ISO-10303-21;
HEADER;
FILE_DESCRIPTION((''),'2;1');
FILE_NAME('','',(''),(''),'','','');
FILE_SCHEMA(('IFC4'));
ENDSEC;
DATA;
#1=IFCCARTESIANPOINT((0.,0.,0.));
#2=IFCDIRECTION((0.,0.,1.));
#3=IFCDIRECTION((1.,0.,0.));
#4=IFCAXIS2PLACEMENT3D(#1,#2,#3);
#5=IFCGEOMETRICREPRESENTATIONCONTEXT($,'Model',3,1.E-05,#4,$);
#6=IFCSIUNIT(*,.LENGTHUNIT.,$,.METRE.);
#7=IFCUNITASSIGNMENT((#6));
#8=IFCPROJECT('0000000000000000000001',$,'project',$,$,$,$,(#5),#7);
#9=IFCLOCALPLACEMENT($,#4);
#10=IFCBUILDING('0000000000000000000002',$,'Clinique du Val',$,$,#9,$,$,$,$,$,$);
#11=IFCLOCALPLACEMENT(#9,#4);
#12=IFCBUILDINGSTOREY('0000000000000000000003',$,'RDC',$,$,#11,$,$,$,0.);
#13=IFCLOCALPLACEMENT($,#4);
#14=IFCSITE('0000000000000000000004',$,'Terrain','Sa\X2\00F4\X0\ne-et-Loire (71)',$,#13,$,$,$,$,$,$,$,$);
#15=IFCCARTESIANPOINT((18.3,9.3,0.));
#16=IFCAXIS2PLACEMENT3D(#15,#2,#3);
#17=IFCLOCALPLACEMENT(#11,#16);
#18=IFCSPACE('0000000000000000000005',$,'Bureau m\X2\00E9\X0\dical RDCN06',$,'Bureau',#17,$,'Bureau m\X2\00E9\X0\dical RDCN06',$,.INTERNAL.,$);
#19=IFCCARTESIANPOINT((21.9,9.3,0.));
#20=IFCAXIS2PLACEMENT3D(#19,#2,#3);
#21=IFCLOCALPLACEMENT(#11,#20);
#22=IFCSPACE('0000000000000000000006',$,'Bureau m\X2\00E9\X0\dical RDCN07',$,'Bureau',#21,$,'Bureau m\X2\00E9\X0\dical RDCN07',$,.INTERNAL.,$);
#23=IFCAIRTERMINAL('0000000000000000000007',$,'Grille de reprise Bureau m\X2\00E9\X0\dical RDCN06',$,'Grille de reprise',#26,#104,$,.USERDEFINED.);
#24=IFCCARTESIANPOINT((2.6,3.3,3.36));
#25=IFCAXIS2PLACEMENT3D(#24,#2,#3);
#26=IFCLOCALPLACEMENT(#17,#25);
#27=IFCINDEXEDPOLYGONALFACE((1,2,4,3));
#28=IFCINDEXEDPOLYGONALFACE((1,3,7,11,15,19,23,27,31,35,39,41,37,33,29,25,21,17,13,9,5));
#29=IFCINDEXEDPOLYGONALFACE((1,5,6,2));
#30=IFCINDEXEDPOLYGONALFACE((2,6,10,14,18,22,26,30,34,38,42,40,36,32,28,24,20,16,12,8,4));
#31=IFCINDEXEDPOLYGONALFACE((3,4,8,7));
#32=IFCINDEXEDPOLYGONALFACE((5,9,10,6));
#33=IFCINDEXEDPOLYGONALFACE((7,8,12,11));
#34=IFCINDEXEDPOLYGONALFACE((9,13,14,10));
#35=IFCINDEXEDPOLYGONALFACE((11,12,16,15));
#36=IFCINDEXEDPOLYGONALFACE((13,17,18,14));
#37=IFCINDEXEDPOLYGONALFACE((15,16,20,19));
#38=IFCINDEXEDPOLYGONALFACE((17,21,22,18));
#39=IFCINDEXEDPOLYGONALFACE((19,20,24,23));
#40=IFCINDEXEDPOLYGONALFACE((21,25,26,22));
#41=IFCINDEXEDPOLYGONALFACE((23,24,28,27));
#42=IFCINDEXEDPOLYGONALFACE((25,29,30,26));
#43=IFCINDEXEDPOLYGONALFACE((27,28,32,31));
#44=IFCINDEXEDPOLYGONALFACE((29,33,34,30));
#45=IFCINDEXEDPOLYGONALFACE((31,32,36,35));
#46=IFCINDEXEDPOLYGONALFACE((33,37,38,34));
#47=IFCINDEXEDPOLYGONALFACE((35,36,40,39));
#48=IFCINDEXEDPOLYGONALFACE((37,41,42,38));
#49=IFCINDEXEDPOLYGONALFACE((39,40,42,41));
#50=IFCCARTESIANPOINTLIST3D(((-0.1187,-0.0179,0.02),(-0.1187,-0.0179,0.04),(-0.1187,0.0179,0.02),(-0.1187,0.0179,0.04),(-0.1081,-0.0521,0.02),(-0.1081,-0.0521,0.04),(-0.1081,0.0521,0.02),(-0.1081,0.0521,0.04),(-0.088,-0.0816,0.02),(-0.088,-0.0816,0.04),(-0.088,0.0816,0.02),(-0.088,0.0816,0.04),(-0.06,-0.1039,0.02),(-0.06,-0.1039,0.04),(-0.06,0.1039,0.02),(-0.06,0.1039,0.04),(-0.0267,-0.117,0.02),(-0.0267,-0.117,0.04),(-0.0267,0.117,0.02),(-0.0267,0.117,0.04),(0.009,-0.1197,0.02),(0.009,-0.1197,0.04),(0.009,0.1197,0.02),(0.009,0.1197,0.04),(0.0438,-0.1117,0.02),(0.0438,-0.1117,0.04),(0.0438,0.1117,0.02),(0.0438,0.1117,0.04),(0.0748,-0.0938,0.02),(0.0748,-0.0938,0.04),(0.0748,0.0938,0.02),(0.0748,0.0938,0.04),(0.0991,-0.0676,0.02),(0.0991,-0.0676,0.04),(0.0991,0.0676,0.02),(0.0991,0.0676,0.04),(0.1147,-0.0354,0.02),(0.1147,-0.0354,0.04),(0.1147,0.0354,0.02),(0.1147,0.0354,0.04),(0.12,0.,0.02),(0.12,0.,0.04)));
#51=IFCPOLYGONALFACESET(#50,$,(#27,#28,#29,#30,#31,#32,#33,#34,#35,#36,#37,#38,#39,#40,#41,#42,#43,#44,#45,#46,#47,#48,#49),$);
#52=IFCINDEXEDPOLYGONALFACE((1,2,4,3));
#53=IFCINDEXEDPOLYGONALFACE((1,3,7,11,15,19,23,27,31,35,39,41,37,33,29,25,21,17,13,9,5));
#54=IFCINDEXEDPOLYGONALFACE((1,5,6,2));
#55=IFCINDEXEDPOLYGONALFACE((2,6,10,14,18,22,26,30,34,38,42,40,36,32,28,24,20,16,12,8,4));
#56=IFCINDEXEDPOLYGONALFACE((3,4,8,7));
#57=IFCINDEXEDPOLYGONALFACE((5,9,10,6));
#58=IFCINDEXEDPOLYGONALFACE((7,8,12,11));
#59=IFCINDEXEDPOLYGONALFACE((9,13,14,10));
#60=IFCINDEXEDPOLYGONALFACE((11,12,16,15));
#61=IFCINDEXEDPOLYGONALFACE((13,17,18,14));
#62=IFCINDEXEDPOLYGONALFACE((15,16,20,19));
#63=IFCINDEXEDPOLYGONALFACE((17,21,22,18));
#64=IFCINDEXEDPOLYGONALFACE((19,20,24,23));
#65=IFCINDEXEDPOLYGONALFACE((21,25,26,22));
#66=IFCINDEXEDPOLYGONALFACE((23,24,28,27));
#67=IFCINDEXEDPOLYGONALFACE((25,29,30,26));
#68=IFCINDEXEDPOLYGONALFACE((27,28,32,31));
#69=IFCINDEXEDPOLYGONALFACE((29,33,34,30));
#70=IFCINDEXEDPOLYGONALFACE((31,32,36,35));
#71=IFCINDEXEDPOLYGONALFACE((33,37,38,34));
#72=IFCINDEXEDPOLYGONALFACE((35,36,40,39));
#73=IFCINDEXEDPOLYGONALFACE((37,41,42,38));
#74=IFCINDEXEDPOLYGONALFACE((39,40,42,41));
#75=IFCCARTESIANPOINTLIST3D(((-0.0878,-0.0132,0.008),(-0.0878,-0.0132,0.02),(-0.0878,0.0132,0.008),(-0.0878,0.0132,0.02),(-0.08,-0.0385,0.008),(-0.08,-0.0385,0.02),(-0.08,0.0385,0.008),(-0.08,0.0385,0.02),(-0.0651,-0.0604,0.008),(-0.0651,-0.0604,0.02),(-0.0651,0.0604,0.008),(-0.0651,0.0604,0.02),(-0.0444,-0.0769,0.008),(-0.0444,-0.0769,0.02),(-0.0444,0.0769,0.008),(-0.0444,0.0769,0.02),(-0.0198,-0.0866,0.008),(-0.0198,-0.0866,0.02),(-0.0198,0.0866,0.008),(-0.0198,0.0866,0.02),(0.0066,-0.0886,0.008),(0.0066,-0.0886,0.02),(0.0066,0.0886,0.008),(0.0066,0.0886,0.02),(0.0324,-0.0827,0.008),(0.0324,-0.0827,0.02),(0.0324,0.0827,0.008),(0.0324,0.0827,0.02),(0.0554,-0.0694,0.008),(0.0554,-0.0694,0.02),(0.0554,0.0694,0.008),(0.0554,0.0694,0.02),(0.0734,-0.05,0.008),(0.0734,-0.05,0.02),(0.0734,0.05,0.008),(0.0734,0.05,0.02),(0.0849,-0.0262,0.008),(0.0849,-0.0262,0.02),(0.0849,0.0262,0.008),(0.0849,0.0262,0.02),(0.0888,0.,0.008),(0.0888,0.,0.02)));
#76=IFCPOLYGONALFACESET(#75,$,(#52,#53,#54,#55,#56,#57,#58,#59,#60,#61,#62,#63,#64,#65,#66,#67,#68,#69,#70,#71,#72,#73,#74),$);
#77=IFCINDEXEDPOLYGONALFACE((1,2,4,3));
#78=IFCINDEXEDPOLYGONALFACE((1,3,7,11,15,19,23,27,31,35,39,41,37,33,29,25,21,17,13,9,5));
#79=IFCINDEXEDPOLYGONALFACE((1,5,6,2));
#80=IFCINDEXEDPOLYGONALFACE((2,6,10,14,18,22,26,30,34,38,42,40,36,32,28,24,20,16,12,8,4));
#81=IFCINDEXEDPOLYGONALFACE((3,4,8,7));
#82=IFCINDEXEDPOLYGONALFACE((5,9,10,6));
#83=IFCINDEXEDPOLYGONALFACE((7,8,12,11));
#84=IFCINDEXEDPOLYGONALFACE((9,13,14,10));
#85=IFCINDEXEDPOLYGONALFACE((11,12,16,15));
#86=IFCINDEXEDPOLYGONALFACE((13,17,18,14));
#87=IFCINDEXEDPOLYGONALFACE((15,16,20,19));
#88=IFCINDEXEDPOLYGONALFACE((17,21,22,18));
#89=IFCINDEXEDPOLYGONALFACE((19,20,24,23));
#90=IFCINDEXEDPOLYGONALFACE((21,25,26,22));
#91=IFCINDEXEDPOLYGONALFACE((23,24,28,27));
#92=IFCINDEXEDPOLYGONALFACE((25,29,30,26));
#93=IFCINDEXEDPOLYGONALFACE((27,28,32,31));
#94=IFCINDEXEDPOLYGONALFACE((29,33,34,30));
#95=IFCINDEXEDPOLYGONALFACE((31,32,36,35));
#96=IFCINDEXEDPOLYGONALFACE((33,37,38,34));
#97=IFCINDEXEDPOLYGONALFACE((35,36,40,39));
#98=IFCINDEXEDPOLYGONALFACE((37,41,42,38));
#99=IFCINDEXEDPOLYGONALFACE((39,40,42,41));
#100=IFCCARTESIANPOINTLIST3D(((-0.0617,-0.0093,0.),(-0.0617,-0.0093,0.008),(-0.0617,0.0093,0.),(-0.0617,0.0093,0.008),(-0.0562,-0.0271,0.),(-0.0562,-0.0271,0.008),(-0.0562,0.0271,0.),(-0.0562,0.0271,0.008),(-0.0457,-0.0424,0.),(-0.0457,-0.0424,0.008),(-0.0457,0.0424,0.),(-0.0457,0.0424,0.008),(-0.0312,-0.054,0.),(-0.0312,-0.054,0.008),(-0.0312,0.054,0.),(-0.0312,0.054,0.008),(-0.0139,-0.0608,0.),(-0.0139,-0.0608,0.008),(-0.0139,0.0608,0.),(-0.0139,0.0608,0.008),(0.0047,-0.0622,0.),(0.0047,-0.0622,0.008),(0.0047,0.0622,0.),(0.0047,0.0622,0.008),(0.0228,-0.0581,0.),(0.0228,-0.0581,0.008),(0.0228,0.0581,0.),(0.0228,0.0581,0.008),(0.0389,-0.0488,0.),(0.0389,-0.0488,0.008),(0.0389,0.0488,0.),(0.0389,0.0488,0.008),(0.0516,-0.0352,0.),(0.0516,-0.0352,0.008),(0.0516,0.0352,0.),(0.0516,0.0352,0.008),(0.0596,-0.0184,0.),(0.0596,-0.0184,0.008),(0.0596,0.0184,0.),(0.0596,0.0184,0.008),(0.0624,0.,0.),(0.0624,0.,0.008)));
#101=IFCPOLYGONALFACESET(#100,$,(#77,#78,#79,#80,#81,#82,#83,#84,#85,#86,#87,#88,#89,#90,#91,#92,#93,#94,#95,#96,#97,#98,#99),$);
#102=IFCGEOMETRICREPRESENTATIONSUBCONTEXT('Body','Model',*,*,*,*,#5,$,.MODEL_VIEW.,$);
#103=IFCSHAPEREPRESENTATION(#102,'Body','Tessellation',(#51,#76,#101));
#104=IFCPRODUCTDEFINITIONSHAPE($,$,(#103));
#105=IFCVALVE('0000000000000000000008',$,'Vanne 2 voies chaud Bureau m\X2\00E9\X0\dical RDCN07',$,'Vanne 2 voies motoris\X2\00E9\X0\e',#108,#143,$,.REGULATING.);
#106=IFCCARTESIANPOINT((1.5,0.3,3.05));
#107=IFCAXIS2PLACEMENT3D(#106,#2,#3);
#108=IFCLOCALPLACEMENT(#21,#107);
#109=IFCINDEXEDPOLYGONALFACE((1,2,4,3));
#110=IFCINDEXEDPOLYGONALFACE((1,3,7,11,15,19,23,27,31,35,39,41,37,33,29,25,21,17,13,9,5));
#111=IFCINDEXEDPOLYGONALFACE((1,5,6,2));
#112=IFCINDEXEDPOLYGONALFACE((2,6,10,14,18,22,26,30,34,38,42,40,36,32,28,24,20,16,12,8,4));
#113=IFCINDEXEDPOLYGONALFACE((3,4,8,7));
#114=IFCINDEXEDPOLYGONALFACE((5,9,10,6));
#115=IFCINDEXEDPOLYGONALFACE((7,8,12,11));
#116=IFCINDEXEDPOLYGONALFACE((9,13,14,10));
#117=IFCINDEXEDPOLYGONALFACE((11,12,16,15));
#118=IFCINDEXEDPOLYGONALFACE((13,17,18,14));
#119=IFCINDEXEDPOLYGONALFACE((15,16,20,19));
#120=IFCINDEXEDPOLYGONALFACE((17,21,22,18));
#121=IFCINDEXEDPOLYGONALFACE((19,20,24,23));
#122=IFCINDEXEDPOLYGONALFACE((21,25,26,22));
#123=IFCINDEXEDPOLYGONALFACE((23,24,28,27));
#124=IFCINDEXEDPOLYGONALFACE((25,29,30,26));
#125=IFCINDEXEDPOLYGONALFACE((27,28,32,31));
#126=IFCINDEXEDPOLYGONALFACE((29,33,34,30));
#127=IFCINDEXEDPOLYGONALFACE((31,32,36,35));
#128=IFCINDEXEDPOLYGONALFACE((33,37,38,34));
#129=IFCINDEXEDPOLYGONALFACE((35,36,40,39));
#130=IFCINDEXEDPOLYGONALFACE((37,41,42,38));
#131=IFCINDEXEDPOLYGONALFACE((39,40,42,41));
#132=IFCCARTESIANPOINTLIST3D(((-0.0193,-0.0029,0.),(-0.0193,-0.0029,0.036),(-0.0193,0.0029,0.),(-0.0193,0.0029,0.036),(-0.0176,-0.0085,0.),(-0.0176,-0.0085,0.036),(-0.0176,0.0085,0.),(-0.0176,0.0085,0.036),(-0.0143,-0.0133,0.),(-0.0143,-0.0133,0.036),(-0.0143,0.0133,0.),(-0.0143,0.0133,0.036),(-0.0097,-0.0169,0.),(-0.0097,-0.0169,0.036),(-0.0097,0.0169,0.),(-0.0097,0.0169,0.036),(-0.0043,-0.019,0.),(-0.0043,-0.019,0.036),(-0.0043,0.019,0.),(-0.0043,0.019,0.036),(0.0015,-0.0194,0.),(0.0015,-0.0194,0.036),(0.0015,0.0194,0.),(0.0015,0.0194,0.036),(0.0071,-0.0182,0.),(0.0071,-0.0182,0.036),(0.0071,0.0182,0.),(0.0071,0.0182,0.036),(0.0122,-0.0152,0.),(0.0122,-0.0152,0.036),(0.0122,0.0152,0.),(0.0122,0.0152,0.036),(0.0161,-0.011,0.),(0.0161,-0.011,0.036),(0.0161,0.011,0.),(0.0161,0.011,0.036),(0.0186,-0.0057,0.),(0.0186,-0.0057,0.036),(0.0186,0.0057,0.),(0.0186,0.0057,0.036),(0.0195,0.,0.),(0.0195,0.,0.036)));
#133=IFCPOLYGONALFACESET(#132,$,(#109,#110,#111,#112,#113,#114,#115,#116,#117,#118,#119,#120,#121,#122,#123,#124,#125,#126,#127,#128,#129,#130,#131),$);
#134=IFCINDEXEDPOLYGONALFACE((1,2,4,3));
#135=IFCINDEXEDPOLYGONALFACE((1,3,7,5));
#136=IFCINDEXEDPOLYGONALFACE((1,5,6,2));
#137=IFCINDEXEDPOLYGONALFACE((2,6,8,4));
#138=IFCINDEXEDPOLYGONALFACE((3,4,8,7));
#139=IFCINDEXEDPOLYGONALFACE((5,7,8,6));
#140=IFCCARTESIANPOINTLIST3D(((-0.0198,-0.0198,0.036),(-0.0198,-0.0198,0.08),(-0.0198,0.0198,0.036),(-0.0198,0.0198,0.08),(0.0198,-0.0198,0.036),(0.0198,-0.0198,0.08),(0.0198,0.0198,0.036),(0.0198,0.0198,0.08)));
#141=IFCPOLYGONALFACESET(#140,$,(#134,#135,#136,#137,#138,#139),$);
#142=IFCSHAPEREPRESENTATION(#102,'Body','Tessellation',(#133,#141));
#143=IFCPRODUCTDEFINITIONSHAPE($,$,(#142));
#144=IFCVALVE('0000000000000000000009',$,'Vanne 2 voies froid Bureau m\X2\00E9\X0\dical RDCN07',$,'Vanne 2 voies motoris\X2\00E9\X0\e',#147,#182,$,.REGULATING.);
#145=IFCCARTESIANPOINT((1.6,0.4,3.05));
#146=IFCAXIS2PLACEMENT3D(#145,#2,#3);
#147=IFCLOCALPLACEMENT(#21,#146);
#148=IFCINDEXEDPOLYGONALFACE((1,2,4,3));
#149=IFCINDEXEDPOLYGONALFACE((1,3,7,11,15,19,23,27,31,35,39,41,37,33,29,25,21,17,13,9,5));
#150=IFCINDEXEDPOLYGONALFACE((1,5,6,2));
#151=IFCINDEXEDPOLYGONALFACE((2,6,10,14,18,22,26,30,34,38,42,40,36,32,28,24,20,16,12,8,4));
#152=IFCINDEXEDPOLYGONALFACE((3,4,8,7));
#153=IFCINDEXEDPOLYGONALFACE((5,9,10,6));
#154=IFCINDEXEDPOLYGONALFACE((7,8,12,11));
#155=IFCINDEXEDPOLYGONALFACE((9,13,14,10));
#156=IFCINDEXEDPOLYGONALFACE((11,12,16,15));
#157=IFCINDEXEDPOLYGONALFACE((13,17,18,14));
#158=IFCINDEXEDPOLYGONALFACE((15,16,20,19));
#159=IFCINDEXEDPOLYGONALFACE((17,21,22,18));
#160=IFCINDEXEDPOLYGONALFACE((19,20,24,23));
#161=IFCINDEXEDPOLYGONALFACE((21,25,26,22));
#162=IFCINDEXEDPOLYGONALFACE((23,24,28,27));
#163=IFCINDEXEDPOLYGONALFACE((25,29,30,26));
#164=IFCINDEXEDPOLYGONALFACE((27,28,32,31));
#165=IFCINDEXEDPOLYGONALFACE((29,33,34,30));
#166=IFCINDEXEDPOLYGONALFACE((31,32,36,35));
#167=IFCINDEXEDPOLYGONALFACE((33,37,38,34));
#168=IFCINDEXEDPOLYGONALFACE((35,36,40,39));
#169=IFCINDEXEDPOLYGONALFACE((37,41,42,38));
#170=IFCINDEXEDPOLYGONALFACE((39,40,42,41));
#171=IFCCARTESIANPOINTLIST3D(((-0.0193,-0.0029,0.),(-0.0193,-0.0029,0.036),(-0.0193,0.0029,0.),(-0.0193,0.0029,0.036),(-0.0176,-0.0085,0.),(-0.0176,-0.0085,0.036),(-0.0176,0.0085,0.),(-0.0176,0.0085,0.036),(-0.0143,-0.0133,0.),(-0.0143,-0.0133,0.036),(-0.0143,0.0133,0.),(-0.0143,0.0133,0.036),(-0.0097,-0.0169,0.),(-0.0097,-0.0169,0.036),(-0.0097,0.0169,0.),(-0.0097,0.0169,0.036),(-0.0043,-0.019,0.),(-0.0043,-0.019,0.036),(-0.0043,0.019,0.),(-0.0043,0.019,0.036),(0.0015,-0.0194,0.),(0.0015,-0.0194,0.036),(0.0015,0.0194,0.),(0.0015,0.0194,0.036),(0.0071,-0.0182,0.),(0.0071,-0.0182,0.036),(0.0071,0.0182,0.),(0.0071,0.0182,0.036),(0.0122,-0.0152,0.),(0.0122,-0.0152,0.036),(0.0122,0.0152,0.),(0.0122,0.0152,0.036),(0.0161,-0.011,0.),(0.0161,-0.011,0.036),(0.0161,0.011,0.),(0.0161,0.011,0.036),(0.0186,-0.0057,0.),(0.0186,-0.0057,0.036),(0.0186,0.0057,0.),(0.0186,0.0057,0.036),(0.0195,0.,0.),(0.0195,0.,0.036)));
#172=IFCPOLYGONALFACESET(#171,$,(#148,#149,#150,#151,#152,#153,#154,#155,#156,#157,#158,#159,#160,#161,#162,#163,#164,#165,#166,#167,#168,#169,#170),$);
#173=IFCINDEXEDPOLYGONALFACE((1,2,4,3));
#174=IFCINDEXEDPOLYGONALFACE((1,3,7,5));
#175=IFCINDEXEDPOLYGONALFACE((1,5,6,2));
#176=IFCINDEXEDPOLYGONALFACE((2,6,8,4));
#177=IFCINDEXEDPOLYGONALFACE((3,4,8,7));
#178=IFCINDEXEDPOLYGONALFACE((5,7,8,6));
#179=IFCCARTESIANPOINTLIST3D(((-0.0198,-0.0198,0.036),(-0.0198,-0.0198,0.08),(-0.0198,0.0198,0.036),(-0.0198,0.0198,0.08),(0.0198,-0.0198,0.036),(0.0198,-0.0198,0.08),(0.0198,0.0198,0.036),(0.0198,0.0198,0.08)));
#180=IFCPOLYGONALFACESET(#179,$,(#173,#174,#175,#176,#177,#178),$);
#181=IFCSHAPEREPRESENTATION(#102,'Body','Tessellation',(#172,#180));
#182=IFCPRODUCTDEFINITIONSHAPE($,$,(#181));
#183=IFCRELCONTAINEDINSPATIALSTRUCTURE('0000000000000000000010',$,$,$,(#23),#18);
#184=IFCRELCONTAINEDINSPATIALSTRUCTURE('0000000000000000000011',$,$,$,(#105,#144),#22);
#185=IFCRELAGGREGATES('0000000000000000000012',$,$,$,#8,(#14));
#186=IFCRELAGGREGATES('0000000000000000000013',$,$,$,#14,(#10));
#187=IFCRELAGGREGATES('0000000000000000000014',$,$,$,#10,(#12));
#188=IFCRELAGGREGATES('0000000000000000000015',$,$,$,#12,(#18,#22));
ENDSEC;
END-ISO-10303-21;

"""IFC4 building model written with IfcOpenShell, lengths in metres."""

from ifc_helpers import new_model, si_unit, frame, frame_2d, origin_with_axes, place, context, subcontext, project, spatial, rectangle, circle, extrude, element, save


model = new_model("IFC4")

# Units and contexts
model_context = context("Model", 3, precision=1e-05, world=origin_with_axes())
body_context = subcontext(model_context, "Body", "Model", "MODEL_VIEW")
ifc_project = project(units=[si_unit("LENGTHUNIT", "METRE")], contexts=[model_context])

# Site, building, storey
site_placement = place(None, origin_with_axes())
site = spatial("IfcSite", under=ifc_project, at=site_placement, Name="Terrain", Description="Saône-et-Loire (71)")
building_placement = place(None, origin_with_axes())
building = spatial("IfcBuilding", under=site, at=building_placement, Name="Clinique du Val")
storey_placement = place(building_placement, origin_with_axes())
storey = spatial("IfcBuildingStorey", under=building, at=storey_placement, Name="RDC", Elevation=0.0)

# Shared definitions
space_1_placement = place(storey_placement, frame((18.3, 9.3, 0.0), z_axis=(0.0, 0.0, 1.0), x_axis=(1.0, 0.0, 0.0)))
space_1 = spatial("IfcSpace", under=storey, at=space_1_placement, Name="Bureau médical RDCN06", ObjectType="Bureau", LongName="Bureau médical RDCN06", PredefinedType="INTERNAL")

# Air terminal
air_terminal_1_placement = place(space_1_placement, frame((2.6, 3.3, 3.36), z_axis=(0.0, 0.0, 1.0), x_axis=(1.0, 0.0, 0.0)))
element("IfcAirTerminal", 1, at=air_terminal_1_placement, inside=space_1, Name="Grille de reprise Bureau médical RDCN06", ObjectType="Grille de reprise", PredefinedType="USERDEFINED", context=body_context, shape_type="SweptSolid", body=[
    extrude(circle(Radius=0.12), frame((0.0, 0.0, 0.02), z_axis=(0.0, 0.0, 1.0), x_axis=(1.0, 0.0, 0.0)), (0.0, 0.0, 1.0), 0.02),
    extrude(circle(Radius=0.0888), frame((0.0, 0.0, 0.008), z_axis=(0.0, 0.0, 1.0), x_axis=(1.0, 0.0, 0.0)), (0.0, 0.0, 1.0), 0.012),
    extrude(circle(Radius=0.0624), origin_with_axes(), (0.0, 0.0, 1.0), 0.008),
])

# Shared definitions
space_2_placement = place(storey_placement, frame((21.9, 9.3, 0.0), z_axis=(0.0, 0.0, 1.0), x_axis=(1.0, 0.0, 0.0)))
space_2 = spatial("IfcSpace", under=storey, at=space_2_placement, Name="Bureau médical RDCN07", ObjectType="Bureau", LongName="Bureau médical RDCN07", PredefinedType="INTERNAL")

# Valves
for number, where, z_axis, x_axis, name in (
    (2, (1.5, 0.3, 3.05), (0.0, 0.0, 1.0), (1.0, 0.0, 0.0), "Vanne 2 voies chaud Bureau médical RDCN07"),
    (3, (1.6, 0.4, 3.05), (0.0, 0.0, 1.0), (1.0, 0.0, 0.0), "Vanne 2 voies froid Bureau médical RDCN07"),
):
    element("IfcValve", number, at=place(space_2_placement, frame(where, z_axis=z_axis, x_axis=x_axis)), inside=space_2, Name=name, ObjectType="Vanne 2 voies motorisée", PredefinedType="REGULATING", context=body_context, shape_type="SweptSolid", body=[
        extrude(circle(Radius=0.0195), origin_with_axes(), (0.0, 0.0, 1.0), 0.036),
        extrude(rectangle(XDim=0.0396, YDim=0.0396, at=frame_2d((0.0198, 0.0198))), frame((-0.0198, -0.0198, 0.036), z_axis=(0.0, 0.0, 1.0), x_axis=(1.0, 0.0, 0.0)), (0.0, 0.0, 1.0), 0.044),
    ])

save(model, "model.ifc")
